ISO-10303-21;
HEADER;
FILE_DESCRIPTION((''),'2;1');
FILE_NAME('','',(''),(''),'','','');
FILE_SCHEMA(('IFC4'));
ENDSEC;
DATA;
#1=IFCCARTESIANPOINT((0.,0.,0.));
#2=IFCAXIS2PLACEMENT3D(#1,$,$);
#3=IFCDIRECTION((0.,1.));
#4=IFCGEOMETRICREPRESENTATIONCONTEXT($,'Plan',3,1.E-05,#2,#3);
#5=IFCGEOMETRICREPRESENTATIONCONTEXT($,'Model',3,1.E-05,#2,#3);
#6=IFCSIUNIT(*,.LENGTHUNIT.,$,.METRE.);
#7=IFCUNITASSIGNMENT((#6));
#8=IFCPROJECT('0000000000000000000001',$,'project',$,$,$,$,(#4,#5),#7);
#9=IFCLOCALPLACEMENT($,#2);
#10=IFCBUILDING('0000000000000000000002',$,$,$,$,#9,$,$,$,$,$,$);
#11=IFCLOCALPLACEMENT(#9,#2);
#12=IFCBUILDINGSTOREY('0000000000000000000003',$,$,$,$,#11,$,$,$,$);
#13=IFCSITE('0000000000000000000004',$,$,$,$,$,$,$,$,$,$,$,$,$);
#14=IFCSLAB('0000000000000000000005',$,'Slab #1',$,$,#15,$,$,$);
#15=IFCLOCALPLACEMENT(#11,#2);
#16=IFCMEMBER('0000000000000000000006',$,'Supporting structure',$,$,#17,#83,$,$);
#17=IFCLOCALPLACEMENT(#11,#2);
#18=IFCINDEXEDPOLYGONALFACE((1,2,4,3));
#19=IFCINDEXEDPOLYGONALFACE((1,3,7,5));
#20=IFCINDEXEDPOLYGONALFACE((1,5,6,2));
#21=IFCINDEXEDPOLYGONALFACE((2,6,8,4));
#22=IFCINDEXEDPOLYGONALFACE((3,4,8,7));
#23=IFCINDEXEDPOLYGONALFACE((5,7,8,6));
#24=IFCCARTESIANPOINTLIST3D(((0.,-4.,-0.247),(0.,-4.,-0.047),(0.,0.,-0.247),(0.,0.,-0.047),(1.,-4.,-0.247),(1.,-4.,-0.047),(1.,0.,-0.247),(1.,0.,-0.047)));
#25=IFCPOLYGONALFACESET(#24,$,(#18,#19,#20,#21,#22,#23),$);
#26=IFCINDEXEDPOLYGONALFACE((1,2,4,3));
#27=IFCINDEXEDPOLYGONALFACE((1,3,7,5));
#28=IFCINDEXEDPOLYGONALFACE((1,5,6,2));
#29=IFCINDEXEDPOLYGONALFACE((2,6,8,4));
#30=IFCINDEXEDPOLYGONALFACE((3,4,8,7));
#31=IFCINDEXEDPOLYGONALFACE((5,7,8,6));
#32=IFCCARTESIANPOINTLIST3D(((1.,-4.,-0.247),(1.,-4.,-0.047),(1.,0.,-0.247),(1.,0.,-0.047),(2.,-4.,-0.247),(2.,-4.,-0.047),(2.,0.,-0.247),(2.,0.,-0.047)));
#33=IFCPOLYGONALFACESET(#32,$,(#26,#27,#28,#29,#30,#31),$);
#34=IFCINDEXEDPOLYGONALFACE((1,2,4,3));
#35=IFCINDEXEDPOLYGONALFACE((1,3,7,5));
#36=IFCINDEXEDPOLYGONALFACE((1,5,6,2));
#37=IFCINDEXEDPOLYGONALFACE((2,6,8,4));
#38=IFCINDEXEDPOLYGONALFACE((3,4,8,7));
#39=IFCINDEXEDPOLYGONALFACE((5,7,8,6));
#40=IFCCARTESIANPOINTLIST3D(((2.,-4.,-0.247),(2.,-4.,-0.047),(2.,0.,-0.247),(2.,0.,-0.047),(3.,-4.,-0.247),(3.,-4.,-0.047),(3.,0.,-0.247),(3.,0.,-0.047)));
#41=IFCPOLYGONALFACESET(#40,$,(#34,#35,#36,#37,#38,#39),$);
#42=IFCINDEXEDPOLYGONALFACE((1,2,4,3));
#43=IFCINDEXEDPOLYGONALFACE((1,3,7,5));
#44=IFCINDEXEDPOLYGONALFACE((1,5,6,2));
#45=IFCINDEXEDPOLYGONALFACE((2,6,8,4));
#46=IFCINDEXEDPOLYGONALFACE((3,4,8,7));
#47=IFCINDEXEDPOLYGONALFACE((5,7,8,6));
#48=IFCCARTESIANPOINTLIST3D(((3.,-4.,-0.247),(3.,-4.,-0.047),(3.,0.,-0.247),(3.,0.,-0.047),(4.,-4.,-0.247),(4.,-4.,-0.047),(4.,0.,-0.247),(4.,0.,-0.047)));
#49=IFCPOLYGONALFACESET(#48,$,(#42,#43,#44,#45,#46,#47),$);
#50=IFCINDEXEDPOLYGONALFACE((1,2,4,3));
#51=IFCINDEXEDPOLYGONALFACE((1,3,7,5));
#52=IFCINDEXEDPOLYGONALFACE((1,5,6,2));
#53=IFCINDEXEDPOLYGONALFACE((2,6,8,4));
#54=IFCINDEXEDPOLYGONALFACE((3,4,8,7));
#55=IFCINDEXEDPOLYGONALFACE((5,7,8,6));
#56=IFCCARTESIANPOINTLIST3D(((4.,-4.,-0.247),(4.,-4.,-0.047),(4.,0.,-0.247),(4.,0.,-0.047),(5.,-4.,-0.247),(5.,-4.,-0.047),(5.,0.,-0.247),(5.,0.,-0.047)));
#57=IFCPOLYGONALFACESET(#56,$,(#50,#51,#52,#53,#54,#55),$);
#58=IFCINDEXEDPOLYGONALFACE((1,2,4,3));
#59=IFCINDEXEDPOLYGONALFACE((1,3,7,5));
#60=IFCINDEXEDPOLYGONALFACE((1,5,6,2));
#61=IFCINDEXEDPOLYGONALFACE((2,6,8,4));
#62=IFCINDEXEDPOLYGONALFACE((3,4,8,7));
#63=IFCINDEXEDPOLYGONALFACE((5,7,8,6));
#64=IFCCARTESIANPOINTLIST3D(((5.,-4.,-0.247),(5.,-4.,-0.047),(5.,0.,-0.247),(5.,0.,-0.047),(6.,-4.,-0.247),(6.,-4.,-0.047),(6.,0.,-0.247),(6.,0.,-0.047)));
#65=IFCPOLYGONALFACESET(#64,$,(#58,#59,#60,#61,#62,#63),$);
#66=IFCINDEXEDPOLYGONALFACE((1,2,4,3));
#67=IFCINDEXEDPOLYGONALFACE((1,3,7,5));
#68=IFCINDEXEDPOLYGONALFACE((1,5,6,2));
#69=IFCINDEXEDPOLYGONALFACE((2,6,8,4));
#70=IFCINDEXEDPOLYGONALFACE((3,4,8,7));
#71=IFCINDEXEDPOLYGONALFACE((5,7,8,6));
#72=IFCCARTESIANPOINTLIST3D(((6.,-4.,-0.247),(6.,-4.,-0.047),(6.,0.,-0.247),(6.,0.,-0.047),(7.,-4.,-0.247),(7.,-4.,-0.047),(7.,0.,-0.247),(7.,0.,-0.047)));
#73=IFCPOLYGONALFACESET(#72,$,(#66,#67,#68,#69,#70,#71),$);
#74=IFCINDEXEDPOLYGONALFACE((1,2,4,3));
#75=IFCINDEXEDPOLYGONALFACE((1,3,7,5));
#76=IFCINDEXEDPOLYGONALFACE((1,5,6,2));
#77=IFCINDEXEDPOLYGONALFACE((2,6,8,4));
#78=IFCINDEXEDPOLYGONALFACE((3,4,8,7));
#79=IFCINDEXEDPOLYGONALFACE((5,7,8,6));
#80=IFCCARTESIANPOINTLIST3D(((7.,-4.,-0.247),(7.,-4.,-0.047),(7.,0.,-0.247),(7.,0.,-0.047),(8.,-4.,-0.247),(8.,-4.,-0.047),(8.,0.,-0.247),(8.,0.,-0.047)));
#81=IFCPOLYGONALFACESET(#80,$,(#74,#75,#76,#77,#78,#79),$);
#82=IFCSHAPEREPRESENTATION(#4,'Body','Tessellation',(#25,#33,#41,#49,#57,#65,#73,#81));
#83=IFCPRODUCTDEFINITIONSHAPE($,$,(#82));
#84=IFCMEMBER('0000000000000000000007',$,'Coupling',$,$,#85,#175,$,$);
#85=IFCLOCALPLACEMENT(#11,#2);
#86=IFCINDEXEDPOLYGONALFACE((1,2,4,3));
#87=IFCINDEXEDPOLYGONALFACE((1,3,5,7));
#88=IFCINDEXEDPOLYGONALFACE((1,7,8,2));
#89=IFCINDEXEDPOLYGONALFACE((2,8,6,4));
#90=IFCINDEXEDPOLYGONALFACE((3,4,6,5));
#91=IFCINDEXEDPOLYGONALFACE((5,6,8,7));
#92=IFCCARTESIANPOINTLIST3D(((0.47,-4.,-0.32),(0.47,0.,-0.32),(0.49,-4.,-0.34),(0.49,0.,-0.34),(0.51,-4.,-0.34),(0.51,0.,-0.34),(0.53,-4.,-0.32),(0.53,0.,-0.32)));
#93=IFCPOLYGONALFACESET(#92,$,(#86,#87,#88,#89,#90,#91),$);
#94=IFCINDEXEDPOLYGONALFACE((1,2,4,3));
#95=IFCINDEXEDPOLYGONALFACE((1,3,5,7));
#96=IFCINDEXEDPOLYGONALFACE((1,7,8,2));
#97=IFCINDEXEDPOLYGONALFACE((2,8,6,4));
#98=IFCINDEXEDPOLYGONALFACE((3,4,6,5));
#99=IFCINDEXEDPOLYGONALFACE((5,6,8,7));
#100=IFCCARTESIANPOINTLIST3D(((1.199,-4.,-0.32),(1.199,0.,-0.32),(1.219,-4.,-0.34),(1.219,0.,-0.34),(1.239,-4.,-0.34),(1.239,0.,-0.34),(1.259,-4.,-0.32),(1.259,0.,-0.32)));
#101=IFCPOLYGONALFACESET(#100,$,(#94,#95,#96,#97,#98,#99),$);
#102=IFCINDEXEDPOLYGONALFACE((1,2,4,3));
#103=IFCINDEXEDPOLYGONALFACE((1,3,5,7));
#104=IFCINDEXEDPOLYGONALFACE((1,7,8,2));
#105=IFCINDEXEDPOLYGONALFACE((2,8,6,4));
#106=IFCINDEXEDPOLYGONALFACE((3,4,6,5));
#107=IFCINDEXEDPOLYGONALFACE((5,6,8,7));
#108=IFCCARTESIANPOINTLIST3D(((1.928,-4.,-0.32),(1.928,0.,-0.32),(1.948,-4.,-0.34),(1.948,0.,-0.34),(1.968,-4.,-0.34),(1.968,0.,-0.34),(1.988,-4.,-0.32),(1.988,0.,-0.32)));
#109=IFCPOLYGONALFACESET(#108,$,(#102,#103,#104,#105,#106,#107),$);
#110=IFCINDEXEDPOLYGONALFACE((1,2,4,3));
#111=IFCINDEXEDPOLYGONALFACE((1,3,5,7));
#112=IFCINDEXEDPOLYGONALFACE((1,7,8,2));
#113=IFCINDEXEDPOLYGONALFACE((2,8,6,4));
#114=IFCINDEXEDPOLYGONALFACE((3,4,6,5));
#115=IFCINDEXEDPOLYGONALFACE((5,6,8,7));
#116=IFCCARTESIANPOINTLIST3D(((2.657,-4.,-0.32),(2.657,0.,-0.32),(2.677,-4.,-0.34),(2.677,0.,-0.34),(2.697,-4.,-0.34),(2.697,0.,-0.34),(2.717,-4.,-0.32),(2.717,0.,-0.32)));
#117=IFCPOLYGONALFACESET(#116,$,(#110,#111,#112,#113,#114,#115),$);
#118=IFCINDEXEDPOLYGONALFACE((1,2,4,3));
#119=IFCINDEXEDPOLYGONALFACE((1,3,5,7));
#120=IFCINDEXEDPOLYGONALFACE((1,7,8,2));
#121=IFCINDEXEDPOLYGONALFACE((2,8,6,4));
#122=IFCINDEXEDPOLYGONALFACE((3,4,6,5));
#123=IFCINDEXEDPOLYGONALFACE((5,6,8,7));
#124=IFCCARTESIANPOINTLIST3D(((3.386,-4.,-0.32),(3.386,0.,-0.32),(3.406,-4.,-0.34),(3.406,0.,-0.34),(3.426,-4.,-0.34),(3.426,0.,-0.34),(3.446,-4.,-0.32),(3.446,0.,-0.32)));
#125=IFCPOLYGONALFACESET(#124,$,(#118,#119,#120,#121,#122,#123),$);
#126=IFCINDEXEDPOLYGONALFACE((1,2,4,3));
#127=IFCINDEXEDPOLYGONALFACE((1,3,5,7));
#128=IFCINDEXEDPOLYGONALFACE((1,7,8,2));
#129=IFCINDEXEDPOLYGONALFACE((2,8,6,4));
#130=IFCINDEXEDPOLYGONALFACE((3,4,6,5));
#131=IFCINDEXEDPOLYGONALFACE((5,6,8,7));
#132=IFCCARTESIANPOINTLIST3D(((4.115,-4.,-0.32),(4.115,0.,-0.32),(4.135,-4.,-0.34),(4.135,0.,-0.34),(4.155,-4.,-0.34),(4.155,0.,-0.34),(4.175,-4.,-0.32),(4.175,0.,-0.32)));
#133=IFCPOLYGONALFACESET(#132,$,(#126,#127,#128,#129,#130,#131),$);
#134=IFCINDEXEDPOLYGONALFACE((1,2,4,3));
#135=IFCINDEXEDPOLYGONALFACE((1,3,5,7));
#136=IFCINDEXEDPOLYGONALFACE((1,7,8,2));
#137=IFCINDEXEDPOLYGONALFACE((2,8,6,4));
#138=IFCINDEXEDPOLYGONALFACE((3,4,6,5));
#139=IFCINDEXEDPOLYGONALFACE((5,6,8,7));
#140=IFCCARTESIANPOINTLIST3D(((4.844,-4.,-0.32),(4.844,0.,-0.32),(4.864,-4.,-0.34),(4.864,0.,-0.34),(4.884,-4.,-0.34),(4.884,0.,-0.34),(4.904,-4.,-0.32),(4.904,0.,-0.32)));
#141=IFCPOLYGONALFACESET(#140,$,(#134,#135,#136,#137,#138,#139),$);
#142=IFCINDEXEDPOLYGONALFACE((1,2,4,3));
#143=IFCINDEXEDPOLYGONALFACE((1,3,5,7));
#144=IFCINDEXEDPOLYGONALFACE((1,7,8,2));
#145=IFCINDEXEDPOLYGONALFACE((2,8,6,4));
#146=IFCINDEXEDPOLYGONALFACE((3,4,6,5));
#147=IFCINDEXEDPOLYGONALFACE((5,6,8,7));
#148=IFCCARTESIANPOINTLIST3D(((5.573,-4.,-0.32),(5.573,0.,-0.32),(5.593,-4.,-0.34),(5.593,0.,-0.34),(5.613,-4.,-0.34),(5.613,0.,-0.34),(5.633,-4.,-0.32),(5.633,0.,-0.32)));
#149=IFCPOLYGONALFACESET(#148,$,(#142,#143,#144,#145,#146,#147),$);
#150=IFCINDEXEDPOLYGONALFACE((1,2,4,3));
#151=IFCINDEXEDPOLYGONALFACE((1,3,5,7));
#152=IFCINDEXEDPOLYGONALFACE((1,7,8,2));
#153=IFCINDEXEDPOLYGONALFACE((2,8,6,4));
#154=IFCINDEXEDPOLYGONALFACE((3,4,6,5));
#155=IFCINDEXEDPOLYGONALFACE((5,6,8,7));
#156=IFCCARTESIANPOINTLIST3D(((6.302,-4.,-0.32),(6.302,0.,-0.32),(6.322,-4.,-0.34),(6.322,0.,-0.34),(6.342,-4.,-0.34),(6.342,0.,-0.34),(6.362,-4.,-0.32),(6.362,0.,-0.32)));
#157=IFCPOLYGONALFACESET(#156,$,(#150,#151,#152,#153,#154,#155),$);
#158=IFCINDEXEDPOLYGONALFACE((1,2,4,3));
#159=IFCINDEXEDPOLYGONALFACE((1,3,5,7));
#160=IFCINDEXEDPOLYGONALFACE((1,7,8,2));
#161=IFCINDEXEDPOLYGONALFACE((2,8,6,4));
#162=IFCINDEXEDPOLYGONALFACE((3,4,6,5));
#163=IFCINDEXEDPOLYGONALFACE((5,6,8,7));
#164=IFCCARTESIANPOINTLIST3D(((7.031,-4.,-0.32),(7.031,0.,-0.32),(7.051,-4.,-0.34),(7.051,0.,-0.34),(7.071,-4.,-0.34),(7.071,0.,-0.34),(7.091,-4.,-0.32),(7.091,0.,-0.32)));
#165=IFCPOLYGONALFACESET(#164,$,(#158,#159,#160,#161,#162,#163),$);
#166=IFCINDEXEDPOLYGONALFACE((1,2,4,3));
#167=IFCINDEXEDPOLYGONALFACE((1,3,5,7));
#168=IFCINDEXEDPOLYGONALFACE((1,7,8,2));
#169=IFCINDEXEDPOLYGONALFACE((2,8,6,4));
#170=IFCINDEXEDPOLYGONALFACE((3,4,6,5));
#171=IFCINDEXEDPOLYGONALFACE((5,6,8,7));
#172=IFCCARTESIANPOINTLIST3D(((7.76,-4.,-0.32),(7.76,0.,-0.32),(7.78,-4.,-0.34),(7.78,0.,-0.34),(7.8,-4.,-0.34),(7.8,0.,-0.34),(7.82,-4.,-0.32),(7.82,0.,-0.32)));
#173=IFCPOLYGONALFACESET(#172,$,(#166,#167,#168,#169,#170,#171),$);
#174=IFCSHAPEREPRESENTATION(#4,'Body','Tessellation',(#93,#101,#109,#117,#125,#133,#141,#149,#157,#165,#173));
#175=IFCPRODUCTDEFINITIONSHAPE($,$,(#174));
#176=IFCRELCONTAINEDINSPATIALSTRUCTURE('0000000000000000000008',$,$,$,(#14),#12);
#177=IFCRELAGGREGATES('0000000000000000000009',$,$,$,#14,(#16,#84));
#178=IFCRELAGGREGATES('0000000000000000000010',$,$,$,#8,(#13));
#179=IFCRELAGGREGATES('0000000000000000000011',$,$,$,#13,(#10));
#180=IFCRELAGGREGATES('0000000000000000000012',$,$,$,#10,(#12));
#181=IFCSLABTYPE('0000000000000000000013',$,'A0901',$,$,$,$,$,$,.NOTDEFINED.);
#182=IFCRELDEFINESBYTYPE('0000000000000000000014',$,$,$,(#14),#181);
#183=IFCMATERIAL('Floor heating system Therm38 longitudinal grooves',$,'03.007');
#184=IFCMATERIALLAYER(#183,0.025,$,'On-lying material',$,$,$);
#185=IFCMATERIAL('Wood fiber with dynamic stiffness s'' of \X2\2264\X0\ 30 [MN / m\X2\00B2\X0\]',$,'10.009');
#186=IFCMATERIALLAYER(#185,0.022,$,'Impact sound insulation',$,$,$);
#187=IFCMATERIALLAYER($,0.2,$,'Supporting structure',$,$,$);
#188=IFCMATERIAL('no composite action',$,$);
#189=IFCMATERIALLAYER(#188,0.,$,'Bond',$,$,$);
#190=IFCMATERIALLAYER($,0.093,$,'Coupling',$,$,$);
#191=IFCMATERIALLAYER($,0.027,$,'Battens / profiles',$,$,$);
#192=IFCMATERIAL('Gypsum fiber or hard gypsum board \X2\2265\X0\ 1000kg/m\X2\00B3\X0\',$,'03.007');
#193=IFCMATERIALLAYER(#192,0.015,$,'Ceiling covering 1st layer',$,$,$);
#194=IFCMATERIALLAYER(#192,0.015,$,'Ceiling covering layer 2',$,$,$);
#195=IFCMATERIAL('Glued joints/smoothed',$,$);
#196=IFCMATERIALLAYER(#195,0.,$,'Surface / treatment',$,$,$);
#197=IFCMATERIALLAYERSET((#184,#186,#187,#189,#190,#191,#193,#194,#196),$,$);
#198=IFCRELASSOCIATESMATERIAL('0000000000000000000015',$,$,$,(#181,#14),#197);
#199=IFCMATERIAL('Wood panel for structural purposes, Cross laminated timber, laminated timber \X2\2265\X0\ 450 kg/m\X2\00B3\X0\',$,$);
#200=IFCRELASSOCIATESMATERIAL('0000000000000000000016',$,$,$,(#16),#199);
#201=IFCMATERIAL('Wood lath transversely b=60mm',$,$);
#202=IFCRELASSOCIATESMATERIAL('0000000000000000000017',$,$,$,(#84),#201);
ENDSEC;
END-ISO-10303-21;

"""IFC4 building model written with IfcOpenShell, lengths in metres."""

from ifc_helpers import new_model, si_unit, direction, frame, frame_2d, origin, place, context, project, spatial, polyline, rectangle, outline, extrude, material, layer, layer_set, type_object, element, aggregate, save


model = new_model("IFC4")

# Units and contexts
plan_context = context("Plan", 3, precision=1e-05, world=origin(), true_north=direction((0.0, 1.0)))
model_context = context("Model", 3, precision=1e-05, world=origin(), true_north=direction((0.0, 1.0)))
ifc_project = project(units=[si_unit("LENGTHUNIT", "METRE")], contexts=[plan_context, model_context])

# Site, building, storey
site = spatial("IfcSite", under=ifc_project)
building_placement = place(None, origin())
building = spatial("IfcBuilding", under=site, at=building_placement)
storey_placement = place(building_placement, origin())
storey = spatial("IfcBuildingStorey", under=building, at=storey_placement)

# Slab, members
ifc_material_1 = material(Name="Floor heating system Therm38 longitudinal grooves", Category="03.007")
ifc_layer_1 = layer(ifc_material_1, 0.025, Name="On-lying material")
ifc_material_2 = material(Name="Wood fiber with dynamic stiffness s' of ≤ 30 [MN / m²]", Category="10.009")
ifc_layer_2 = layer(ifc_material_2, 0.022, Name="Impact sound insulation")
ifc_layer_3 = layer(None, 0.2, Name="Supporting structure")
ifc_material_3 = material(Name="no composite action")
ifc_layer_4 = layer(ifc_material_3, 0.0, Name="Bond")
ifc_layer_5 = layer(None, 0.093, Name="Coupling")
ifc_layer_6 = layer(None, 0.027, Name="Battens / profiles")
ifc_material_4 = material(Name="Gypsum fiber or hard gypsum board ≥ 1000kg/m³", Category="03.007")
ifc_layer_7 = layer(ifc_material_4, 0.015, Name="Ceiling covering 1st layer")
ifc_layer_8 = layer(ifc_material_4, 0.015, Name="Ceiling covering layer 2")
ifc_material_5 = material(Name="Glued joints/smoothed")
ifc_layer_9 = layer(ifc_material_5, 0.0, Name="Surface / treatment")
ifc_layer_set = layer_set([ifc_layer_1, ifc_layer_2, ifc_layer_3, ifc_layer_4, ifc_layer_5, ifc_layer_6, ifc_layer_7, ifc_layer_8, ifc_layer_9])
slab_type = type_object("IfcSlabType", Name="A0901", PredefinedType="NOTDEFINED", material=ifc_layer_set)
slab_placement = place(None, frame((0.0, 0.0, 0.0), z_axis=(0.0, 0.0, -1.0), x_axis=(1.0, 0.0, 0.0)))
slab = element("IfcSlab", 1, at=slab_placement, inside=storey, type_object=slab_type, material=ifc_layer_set, Name="Slab #1")
ifc_material_6 = material(Name="Wood panel for structural purposes, Cross laminated timber, laminated timber ≥ 450 kg/m³")
member_1_placement = place(slab_placement, origin())
member_1 = element("IfcMember", 2, at=member_1_placement, material=ifc_material_6, Name="Supporting structure", context=plan_context, shape_type="SweptSolid", body=[
    extrude(rectangle(XDim=1.0, YDim=0.2, at=frame_2d((0.5, 0.1), x_axis=(1.0, 0.0))), frame((0.0, 4.0, 0.047), z_axis=(0.0, -1.0, 0.0), x_axis=(1.0, 0.0, 0.0)), (0.0, 0.0, 1.0), 4.0),
    extrude(rectangle(XDim=1.0, YDim=0.2, at=frame_2d((0.5, 0.1), x_axis=(1.0, 0.0))), frame((1.0, 4.0, 0.047), z_axis=(0.0, -1.0, 0.0), x_axis=(1.0, 0.0, 0.0)), (0.0, 0.0, 1.0), 4.0),
    extrude(rectangle(XDim=1.0, YDim=0.2, at=frame_2d((0.5, 0.1), x_axis=(1.0, 0.0))), frame((2.0, 4.0, 0.047), z_axis=(0.0, -1.0, 0.0), x_axis=(1.0, 0.0, 0.0)), (0.0, 0.0, 1.0), 4.0),
    extrude(rectangle(XDim=1.0, YDim=0.2, at=frame_2d((0.5, 0.1), x_axis=(1.0, 0.0))), frame((3.0, 4.0, 0.047), z_axis=(0.0, -1.0, 0.0), x_axis=(1.0, 0.0, 0.0)), (0.0, 0.0, 1.0), 4.0),
    extrude(rectangle(XDim=1.0, YDim=0.2, at=frame_2d((0.5, 0.1), x_axis=(1.0, 0.0))), frame((4.0, 4.0, 0.047), z_axis=(0.0, -1.0, 0.0), x_axis=(1.0, 0.0, 0.0)), (0.0, 0.0, 1.0), 4.0),
    extrude(rectangle(XDim=1.0, YDim=0.2, at=frame_2d((0.5, 0.1), x_axis=(1.0, 0.0))), frame((5.0, 4.0, 0.047), z_axis=(0.0, -1.0, 0.0), x_axis=(1.0, 0.0, 0.0)), (0.0, 0.0, 1.0), 4.0),
    extrude(rectangle(XDim=1.0, YDim=0.2, at=frame_2d((0.5, 0.1), x_axis=(1.0, 0.0))), frame((6.0, 4.0, 0.047), z_axis=(0.0, -1.0, 0.0), x_axis=(1.0, 0.0, 0.0)), (0.0, 0.0, 1.0), 4.0),
    extrude(rectangle(XDim=1.0, YDim=0.2, at=frame_2d((0.5, 0.1), x_axis=(1.0, 0.0))), frame((7.0, 4.0, 0.047), z_axis=(0.0, -1.0, 0.0), x_axis=(1.0, 0.0, 0.0)), (0.0, 0.0, 1.0), 4.0),
])
ifc_material_7 = material(Name="Wood lath transversely b=60mm")
member_2_placement = place(slab_placement, origin())
member_2 = element("IfcMember", 3, at=member_2_placement, material=ifc_material_7, Name="Coupling", context=plan_context, shape_type="SweptSolid", body=[
    extrude(outline(polyline([(0.0, 0.0), (0.06, 0.0), (0.04, 0.02), (0.02, 0.02), (0.0, 0.0)])), frame((0.47, 4.0, 0.32), z_axis=(0.0, -1.0, 0.0), x_axis=(1.0, 0.0, 0.0)), (0.0, 0.0, 1.0), 4.0),
    extrude(outline(polyline([(0.0, 0.0), (0.06, 0.0), (0.04, 0.02), (0.02, 0.02), (0.0, 0.0)])), frame((1.199, 4.0, 0.32), z_axis=(0.0, -1.0, 0.0), x_axis=(1.0, 0.0, 0.0)), (0.0, 0.0, 1.0), 4.0),
    extrude(outline(polyline([(0.0, 0.0), (0.06, 0.0), (0.04, 0.02), (0.02, 0.02), (0.0, 0.0)])), frame((1.928, 4.0, 0.32), z_axis=(0.0, -1.0, 0.0), x_axis=(1.0, 0.0, 0.0)), (0.0, 0.0, 1.0), 4.0),
    extrude(outline(polyline([(0.0, 0.0), (0.06, 0.0), (0.04, 0.02), (0.02, 0.02), (0.0, 0.0)])), frame((2.657, 4.0, 0.32), z_axis=(0.0, -1.0, 0.0), x_axis=(1.0, 0.0, 0.0)), (0.0, 0.0, 1.0), 4.0),
    extrude(outline(polyline([(0.0, 0.0), (0.06, 0.0), (0.04, 0.02), (0.02, 0.02), (0.0, 0.0)])), frame((3.386, 4.0, 0.32), z_axis=(0.0, -1.0, 0.0), x_axis=(1.0, 0.0, 0.0)), (0.0, 0.0, 1.0), 4.0),
    extrude(outline(polyline([(0.0, 0.0), (0.06, 0.0), (0.04, 0.02), (0.02, 0.02), (0.0, 0.0)])), frame((4.115, 4.0, 0.32), z_axis=(0.0, -1.0, 0.0), x_axis=(1.0, 0.0, 0.0)), (0.0, 0.0, 1.0), 4.0),
    extrude(outline(polyline([(0.0, 0.0), (0.06, 0.0), (0.04, 0.02), (0.02, 0.02), (0.0, 0.0)])), frame((4.844, 4.0, 0.32), z_axis=(0.0, -1.0, 0.0), x_axis=(1.0, 0.0, 0.0)), (0.0, 0.0, 1.0), 4.0),
    extrude(outline(polyline([(0.0, 0.0), (0.06, 0.0), (0.04, 0.02), (0.02, 0.02), (0.0, 0.0)])), frame((5.573, 4.0, 0.32), z_axis=(0.0, -1.0, 0.0), x_axis=(1.0, 0.0, 0.0)), (0.0, 0.0, 1.0), 4.0),
    extrude(outline(polyline([(0.0, 0.0), (0.06, 0.0), (0.04, 0.02), (0.02, 0.02), (0.0, 0.0)])), frame((6.302, 4.0, 0.32), z_axis=(0.0, -1.0, 0.0), x_axis=(1.0, 0.0, 0.0)), (0.0, 0.0, 1.0), 4.0),
    extrude(outline(polyline([(0.0, 0.0), (0.06, 0.0), (0.04, 0.02), (0.02, 0.02), (0.0, 0.0)])), frame((7.031, 4.0, 0.32), z_axis=(0.0, -1.0, 0.0), x_axis=(1.0, 0.0, 0.0)), (0.0, 0.0, 1.0), 4.0),
    extrude(outline(polyline([(0.0, 0.0), (0.06, 0.0), (0.04, 0.02), (0.02, 0.02), (0.0, 0.0)])), frame((7.76, 4.0, 0.32), z_axis=(0.0, -1.0, 0.0), x_axis=(1.0, 0.0, 0.0)), (0.0, 0.0, 1.0), 4.0),
])
aggregate(slab, [member_1, member_2])

save(model, "model.ifc")
